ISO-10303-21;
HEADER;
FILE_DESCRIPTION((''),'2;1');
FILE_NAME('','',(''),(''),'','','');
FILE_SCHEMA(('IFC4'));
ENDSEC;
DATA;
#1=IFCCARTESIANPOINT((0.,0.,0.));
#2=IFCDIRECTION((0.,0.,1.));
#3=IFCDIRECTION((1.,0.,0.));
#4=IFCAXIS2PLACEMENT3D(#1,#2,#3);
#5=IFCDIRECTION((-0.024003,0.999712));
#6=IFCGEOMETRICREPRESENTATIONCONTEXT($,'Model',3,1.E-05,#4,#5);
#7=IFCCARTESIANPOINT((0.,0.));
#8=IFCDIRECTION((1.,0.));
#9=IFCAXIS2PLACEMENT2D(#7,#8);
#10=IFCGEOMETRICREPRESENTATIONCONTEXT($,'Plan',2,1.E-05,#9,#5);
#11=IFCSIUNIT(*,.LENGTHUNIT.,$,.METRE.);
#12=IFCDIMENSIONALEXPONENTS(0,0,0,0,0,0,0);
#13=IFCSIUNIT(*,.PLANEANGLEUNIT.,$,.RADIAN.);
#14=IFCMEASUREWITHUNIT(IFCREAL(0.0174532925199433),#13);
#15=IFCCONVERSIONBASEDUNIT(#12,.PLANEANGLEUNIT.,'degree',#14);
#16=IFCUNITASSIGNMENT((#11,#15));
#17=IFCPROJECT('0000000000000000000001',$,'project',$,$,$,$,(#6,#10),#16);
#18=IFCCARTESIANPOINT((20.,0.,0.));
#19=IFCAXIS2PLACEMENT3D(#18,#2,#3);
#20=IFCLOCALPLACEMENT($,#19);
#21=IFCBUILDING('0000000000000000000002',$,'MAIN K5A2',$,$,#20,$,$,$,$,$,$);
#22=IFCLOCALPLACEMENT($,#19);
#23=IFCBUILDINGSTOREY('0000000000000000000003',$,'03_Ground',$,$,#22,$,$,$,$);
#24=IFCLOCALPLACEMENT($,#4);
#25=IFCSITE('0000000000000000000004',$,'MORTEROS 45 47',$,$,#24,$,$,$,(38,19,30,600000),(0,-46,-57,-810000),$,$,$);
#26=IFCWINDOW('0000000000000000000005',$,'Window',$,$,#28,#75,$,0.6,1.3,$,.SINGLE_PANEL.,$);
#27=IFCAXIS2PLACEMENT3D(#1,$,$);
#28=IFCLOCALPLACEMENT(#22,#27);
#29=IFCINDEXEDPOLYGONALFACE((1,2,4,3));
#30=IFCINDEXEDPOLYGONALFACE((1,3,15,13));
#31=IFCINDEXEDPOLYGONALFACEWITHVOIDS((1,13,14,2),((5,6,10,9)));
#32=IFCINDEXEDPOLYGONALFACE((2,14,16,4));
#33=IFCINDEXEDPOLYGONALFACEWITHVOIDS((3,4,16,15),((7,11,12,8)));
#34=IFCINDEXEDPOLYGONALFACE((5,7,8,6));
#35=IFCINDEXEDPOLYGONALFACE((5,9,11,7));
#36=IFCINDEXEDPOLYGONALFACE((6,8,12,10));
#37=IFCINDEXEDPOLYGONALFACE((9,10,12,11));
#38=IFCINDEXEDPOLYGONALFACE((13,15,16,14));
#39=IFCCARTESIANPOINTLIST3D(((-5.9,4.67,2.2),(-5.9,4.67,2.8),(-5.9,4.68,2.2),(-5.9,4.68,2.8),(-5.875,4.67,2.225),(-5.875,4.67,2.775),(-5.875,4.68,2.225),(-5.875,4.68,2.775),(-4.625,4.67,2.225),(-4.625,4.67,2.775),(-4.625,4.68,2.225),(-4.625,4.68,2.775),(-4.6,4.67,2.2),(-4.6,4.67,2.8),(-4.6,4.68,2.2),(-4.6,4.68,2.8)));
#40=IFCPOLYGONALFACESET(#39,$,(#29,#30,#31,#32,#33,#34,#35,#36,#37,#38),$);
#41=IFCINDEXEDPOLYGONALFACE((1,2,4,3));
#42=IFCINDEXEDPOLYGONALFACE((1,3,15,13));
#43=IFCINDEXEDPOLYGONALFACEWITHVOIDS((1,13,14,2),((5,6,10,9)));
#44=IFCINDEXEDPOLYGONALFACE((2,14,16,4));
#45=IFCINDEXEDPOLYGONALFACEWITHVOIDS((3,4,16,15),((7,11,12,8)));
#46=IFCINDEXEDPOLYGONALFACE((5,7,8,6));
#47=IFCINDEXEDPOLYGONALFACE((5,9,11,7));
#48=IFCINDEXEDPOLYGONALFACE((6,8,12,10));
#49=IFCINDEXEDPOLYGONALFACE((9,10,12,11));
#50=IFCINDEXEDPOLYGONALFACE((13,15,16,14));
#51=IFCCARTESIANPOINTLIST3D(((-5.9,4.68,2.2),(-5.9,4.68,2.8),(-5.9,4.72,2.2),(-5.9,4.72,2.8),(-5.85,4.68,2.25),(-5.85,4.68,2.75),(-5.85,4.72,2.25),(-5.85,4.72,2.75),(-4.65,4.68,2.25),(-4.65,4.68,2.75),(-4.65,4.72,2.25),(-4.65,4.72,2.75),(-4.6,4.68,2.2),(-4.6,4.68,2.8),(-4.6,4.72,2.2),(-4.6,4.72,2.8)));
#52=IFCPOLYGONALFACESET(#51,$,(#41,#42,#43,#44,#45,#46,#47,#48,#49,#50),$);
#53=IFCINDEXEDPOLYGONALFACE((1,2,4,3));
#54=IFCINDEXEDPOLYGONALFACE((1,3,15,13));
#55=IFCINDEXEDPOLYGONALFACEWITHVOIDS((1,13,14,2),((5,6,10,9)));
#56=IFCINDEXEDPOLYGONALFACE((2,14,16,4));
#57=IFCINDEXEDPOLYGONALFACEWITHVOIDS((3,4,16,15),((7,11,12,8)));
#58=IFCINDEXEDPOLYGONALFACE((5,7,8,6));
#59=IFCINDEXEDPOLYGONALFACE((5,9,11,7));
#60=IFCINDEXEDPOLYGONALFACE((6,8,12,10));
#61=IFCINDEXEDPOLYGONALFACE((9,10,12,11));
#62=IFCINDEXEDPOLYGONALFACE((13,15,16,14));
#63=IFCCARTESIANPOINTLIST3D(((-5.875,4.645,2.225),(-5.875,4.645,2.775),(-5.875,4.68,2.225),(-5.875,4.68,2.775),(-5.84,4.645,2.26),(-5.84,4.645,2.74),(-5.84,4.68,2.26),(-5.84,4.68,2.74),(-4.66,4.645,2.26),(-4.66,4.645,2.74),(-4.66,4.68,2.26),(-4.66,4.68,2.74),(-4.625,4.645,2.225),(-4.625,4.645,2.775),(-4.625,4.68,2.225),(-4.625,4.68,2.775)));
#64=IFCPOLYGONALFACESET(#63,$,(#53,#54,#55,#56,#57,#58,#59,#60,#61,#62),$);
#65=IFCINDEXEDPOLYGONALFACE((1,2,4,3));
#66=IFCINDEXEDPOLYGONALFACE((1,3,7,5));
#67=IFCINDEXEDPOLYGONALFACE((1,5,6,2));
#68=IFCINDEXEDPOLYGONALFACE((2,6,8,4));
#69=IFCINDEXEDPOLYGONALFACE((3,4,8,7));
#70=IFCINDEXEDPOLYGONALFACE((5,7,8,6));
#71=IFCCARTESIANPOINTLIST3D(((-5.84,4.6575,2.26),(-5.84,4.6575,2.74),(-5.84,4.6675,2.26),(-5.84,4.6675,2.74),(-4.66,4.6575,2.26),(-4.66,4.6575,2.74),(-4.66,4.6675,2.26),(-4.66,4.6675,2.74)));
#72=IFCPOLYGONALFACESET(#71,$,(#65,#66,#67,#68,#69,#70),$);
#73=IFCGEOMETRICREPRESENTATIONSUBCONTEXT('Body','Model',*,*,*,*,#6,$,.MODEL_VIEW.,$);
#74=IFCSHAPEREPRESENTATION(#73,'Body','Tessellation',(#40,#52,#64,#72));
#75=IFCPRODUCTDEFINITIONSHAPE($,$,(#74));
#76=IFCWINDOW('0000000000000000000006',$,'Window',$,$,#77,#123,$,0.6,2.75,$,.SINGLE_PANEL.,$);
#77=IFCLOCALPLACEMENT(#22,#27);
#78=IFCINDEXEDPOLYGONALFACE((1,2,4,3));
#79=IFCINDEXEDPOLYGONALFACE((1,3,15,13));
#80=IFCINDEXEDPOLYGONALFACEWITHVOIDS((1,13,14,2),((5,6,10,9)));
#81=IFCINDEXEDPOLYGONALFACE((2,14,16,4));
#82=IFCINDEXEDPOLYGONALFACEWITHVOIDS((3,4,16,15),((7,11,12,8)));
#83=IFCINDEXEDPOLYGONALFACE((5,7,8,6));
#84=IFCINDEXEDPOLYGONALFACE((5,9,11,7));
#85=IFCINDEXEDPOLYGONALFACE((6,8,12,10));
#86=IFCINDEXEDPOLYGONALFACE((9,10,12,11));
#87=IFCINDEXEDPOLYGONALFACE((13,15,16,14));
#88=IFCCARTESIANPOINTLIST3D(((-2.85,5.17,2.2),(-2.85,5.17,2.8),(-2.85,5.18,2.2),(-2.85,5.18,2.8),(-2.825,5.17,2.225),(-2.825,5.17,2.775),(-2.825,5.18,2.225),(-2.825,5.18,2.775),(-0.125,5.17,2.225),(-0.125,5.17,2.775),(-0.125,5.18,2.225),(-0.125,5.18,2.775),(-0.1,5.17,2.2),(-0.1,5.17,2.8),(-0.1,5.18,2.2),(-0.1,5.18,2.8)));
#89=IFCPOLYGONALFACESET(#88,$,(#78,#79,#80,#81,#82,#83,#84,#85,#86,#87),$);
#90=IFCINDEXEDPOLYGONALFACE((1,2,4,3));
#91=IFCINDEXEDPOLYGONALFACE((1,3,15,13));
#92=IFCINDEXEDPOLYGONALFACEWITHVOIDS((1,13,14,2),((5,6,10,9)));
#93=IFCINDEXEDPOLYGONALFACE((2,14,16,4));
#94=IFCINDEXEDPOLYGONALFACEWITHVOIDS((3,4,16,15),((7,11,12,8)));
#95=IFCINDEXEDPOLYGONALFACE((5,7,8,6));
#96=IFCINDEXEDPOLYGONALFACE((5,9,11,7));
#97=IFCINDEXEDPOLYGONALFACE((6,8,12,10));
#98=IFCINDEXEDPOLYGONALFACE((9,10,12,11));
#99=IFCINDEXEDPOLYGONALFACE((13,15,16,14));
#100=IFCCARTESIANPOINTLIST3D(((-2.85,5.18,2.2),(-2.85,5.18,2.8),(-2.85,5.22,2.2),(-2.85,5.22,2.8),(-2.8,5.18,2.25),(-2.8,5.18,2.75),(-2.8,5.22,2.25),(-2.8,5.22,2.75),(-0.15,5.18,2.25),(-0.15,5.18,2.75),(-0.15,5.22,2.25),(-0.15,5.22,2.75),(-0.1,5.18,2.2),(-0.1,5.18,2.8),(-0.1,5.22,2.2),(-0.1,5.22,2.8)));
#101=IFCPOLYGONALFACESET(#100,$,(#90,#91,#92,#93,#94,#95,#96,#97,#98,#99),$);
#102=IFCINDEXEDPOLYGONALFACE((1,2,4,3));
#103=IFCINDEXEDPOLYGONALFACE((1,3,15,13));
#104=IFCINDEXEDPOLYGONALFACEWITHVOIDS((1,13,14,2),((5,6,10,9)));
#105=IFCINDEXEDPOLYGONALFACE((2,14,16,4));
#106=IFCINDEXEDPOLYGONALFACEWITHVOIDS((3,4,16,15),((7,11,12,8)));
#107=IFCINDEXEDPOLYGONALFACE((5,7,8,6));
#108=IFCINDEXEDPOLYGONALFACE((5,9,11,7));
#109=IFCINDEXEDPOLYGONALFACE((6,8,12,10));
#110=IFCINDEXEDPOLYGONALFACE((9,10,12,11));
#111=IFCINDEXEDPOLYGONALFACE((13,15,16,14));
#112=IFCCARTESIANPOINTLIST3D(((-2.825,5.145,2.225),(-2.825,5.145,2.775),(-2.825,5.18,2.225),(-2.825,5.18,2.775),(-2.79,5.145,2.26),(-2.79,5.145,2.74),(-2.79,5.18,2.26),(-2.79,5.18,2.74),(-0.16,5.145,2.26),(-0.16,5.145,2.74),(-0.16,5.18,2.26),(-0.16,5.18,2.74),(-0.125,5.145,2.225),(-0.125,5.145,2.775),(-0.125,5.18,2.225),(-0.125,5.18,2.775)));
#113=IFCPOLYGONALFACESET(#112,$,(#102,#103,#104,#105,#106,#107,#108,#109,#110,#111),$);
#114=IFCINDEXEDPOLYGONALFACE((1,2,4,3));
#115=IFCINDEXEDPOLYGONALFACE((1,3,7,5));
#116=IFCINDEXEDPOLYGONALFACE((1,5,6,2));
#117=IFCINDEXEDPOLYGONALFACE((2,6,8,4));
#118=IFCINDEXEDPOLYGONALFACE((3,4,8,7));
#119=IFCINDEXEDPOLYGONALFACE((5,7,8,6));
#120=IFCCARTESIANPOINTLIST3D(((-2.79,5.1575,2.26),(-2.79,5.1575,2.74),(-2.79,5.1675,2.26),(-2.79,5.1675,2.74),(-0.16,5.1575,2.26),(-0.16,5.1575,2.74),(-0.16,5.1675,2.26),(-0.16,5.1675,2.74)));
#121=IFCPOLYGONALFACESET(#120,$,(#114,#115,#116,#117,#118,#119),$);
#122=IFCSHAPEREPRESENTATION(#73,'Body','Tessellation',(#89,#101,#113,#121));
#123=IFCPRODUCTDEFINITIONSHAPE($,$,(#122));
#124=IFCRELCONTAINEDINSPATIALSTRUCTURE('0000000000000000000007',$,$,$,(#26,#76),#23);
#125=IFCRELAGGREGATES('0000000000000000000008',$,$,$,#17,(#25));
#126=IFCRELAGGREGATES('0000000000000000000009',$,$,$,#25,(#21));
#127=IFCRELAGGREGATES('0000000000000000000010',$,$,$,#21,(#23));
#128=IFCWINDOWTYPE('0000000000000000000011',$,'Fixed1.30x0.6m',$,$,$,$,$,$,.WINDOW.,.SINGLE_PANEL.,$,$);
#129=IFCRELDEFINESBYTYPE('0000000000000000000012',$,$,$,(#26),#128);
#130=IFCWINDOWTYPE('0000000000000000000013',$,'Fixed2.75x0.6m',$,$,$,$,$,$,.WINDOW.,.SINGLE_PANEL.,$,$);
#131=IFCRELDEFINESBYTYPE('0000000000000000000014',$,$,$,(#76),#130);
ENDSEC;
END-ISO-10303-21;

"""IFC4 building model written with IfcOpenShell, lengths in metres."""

from ifc_helpers import new_model, entity, si_unit, converted_unit, direction, frame, origin_with_axes, origin_2d_with_axis, place, context, subcontext, project, spatial, line, indexed_curve, outline, extrude, shape, source, transform, mapped, type_object, element, save


model = new_model("IFC4")

# Units and contexts
model_context = context("Model", 3, precision=1e-05, world=origin_with_axes(), true_north=direction((-0.024003, 0.999712)))
plan_context = context("Plan", 2, precision=1e-05, world=origin_2d_with_axis(), true_north=direction((-0.024003, 0.999712)))
body_context_1 = subcontext(model_context, "Body", "Model", "MODEL_VIEW")
body_context_2 = subcontext(plan_context, "Body", "Plan", "PLAN_VIEW")
ifc_project = project(units=[si_unit("LENGTHUNIT", "METRE"), converted_unit("PLANEANGLEUNIT", "degree", entity("IfcReal", 0.0174532925199433), si_unit("PLANEANGLEUNIT", "RADIAN"), dimensions=[0, 0, 0, 0, 0, 0, 0])], contexts=[model_context, plan_context])

# Site, building, storey
site_placement = place(None, origin_with_axes())
site = spatial("IfcSite", under=ifc_project, at=site_placement, Name="MORTEROS 45 47", RefLatitude=(38, 19, 30, 600000), RefLongitude=(0, -46, -57, -810000))
building_placement = place(None, frame((20.0, 0.0, 0.0), z_axis=(0.0, 0.0, 1.0), x_axis=(1.0, 0.0, 0.0)))
building = spatial("IfcBuilding", under=site, at=building_placement, Name="MAIN K5A2")
storey_placement = place(None, frame((20.0, 0.0, 0.0), z_axis=(0.0, 0.0, 1.0), x_axis=(1.0, 0.0, 0.0)))
storey = spatial("IfcBuildingStorey", under=building, at=storey_placement, Name="03_Ground")

# Windows
window_type_1 = type_object("IfcWindowType", Name="Fixed1.30x0.6m", PartitioningType="SINGLE_PANEL", PredefinedType="WINDOW")
shared_shape_1 = source(origin_with_axes(), body_context_1, "Body", "SolidModel", [
    extrude(outline(indexed_curve([(0.0, 0.0), (1.3, 0.0), (1.3, 0.6), (0.0, 0.6)], segments=[line(1, 2, 3, 4, 1)]), holes=[indexed_curve([(0.025, 0.025), (1.275, 0.025), (1.275, 0.575), (0.025, 0.575)], segments=[line(1, 2, 3, 4, 1)])]), frame((0.0, 0.09, 0.0), z_axis=(0.0, -1.0, 0.0), x_axis=(1.0, 0.0, 0.0)), (0.0, 0.0, -1.0), 0.01),
    extrude(outline(indexed_curve([(0.0, 0.0), (1.3, 0.0), (1.3, 0.6), (0.0, 0.6)], segments=[line(1, 2, 3, 4, 1)]), holes=[indexed_curve([(0.05, 0.05), (1.25, 0.05), (1.25, 0.55), (0.05, 0.55)], segments=[line(1, 2, 3, 4, 1)])]), frame((0.0, 0.05, 0.0), z_axis=(0.0, -1.0, 0.0), x_axis=(1.0, 0.0, 0.0)), (0.0, 0.0, -1.0), 0.04),
    extrude(outline(indexed_curve([(0.0, 0.0), (1.25, 0.0), (1.25, 0.55), (0.0, 0.55)], segments=[line(1, 2, 3, 4, 1)]), holes=[indexed_curve([(0.035, 0.035), (1.215, 0.035), (1.215, 0.515), (0.035, 0.515)], segments=[line(1, 2, 3, 4, 1)])]), frame((0.025, 0.09, 0.025), z_axis=(0.0, -1.0, 0.0), x_axis=(1.0, 0.0, 0.0)), (0.0, 0.0, -1.0), 0.035),
    extrude(outline(indexed_curve([(0.035, 0.035), (1.215, 0.035), (1.215, 0.515), (0.035, 0.515)], segments=[line(1, 2, 3, 4, 1)])), frame((0.025, 0.1025, 0.025), z_axis=(0.0, -1.0, 0.0), x_axis=(1.0, 0.0, 0.0)), (0.0, 0.0, -1.0), 0.01),
])
shared_shape_2 = source(origin_with_axes(), body_context_2, "Body", "Curve2D", [
    entity("IfcIndexedPolyCurve", entity("IfcCartesianPointList2D", [[0.05, 0.05], [1.25, 0.05]])),
    entity("IfcIndexedPolyCurve", entity("IfcCartesianPointList2D", [[0.0, 0.1], [0.025, 0.1], [0.025, 0.09], [0.05, 0.09], [0.05, 0.05], [0.0, 0.05]]), [entity("IfcLineIndex", [1, 2, 3, 4, 5, 6, 1])]),
    entity("IfcIndexedPolyCurve", entity("IfcCartesianPointList2D", [[1.3, 0.1], [1.275, 0.1], [1.275, 0.09], [1.25, 0.09], [1.25, 0.05], [1.3, 0.05]]), [entity("IfcLineIndex", [1, 2, 3, 4, 5, 6, 1])]),
    entity("IfcIndexedPolyCurve", entity("IfcCartesianPointList2D", [[0.025, 0.09], [0.06, 0.09], [0.06, 0.125], [0.025, 0.125]]), [entity("IfcLineIndex", [1, 2, 3, 4, 1])]),
    entity("IfcIndexedPolyCurve", entity("IfcCartesianPointList2D", [[1.275, 0.09], [1.24, 0.09], [1.24, 0.125], [1.275, 0.125]]), [entity("IfcLineIndex", [1, 2, 3, 4, 1])]),
    entity("IfcIndexedPolyCurve", entity("IfcCartesianPointList2D", [[0.06, 0.09], [1.24, 0.09]])),
    entity("IfcIndexedPolyCurve", entity("IfcCartesianPointList2D", [[0.06, 0.125], [1.24, 0.125]])),
    entity("IfcIndexedPolyCurve", entity("IfcCartesianPointList2D", [[0.06, 0.1075], [1.24, 0.1075]])),
])
window_1_placement = place(None, frame((15.4, 4.77, 2.2), z_axis=(0.0, 0.0, 1.0), x_axis=(-1.0, 0.0, 0.0)))
element("IfcWindow", 1, at=window_1_placement, inside=storey, type_object=window_type_1, Name="Window", OverallHeight=0.6, OverallWidth=1.3, PartitioningType="SINGLE_PANEL", shapes=[
    shape(body_context_1, "Body", "MappedRepresentation", [mapped(shared_shape_1, transform((0.0, 0.0, 0.0), x_axis=(1.0, 0.0, 0.0), y_axis=(0.0, 1.0, 0.0), z_axis=(0.0, 0.0, 1.0), scale=1.0))]),
    shape(body_context_2, "Body", "MappedRepresentation", [mapped(shared_shape_2, transform((0.0, 0.0, 0.0), x_axis=(1.0, 0.0, 0.0), y_axis=(0.0, 1.0, 0.0), z_axis=(0.0, 0.0, 1.0), scale=1.0))]),
])
window_type_2 = type_object("IfcWindowType", Name="Fixed2.75x0.6m", PartitioningType="SINGLE_PANEL", PredefinedType="WINDOW")
shared_shape_3 = source(origin_with_axes(), body_context_1, "Body", "SolidModel", [
    extrude(outline(indexed_curve([(0.0, 0.0), (2.75, 0.0), (2.75, 0.6), (0.0, 0.6)], segments=[line(1, 2, 3, 4, 1)]), holes=[indexed_curve([(0.025, 0.025), (2.725, 0.025), (2.725, 0.575), (0.025, 0.575)], segments=[line(1, 2, 3, 4, 1)])]), frame((0.0, 0.09, 0.0), z_axis=(0.0, -1.0, 0.0), x_axis=(1.0, 0.0, 0.0)), (0.0, 0.0, -1.0), 0.01),
    extrude(outline(indexed_curve([(0.0, 0.0), (2.75, 0.0), (2.75, 0.6), (0.0, 0.6)], segments=[line(1, 2, 3, 4, 1)]), holes=[indexed_curve([(0.05, 0.05), (2.7, 0.05), (2.7, 0.55), (0.05, 0.55)], segments=[line(1, 2, 3, 4, 1)])]), frame((0.0, 0.05, 0.0), z_axis=(0.0, -1.0, 0.0), x_axis=(1.0, 0.0, 0.0)), (0.0, 0.0, -1.0), 0.04),
    extrude(outline(indexed_curve([(0.0, 0.0), (2.7, 0.0), (2.7, 0.55), (0.0, 0.55)], segments=[line(1, 2, 3, 4, 1)]), holes=[indexed_curve([(0.035, 0.035), (2.665, 0.035), (2.665, 0.515), (0.035, 0.515)], segments=[line(1, 2, 3, 4, 1)])]), frame((0.025, 0.09, 0.025), z_axis=(0.0, -1.0, 0.0), x_axis=(1.0, 0.0, 0.0)), (0.0, 0.0, -1.0), 0.035),
    extrude(outline(indexed_curve([(0.035, 0.035), (2.665, 0.035), (2.665, 0.515), (0.035, 0.515)], segments=[line(1, 2, 3, 4, 1)])), frame((0.025, 0.1025, 0.025), z_axis=(0.0, -1.0, 0.0), x_axis=(1.0, 0.0, 0.0)), (0.0, 0.0, -1.0), 0.01),
])
shared_shape_4 = source(origin_with_axes(), body_context_2, "Body", "Curve2D", [
    entity("IfcIndexedPolyCurve", entity("IfcCartesianPointList2D", [[0.05, 0.05], [2.7, 0.05]])),
    entity("IfcIndexedPolyCurve", entity("IfcCartesianPointList2D", [[0.0, 0.1], [0.025, 0.1], [0.025, 0.09], [0.05, 0.09], [0.05, 0.05], [0.0, 0.05]]), [entity("IfcLineIndex", [1, 2, 3, 4, 5, 6, 1])]),
    entity("IfcIndexedPolyCurve", entity("IfcCartesianPointList2D", [[2.75, 0.1], [2.725, 0.1], [2.725, 0.09], [2.7, 0.09], [2.7, 0.05], [2.75, 0.05]]), [entity("IfcLineIndex", [1, 2, 3, 4, 5, 6, 1])]),
    entity("IfcIndexedPolyCurve", entity("IfcCartesianPointList2D", [[0.025, 0.09], [0.06, 0.09], [0.06, 0.125], [0.025, 0.125]]), [entity("IfcLineIndex", [1, 2, 3, 4, 1])]),
    entity("IfcIndexedPolyCurve", entity("IfcCartesianPointList2D", [[2.725, 0.09], [2.69, 0.09], [2.69, 0.125], [2.725, 0.125]]), [entity("IfcLineIndex", [1, 2, 3, 4, 1])]),
    entity("IfcIndexedPolyCurve", entity("IfcCartesianPointList2D", [[0.06, 0.09], [2.69, 0.09]])),
    entity("IfcIndexedPolyCurve", entity("IfcCartesianPointList2D", [[0.06, 0.125], [2.69, 0.125]])),
    entity("IfcIndexedPolyCurve", entity("IfcCartesianPointList2D", [[0.06, 0.1075], [2.69, 0.1075]])),
])
window_2_placement = place(None, frame((19.9, 5.27, 2.2), z_axis=(0.0, 0.0, 1.0), x_axis=(-1.0, 0.0, 0.0)))
element("IfcWindow", 2, at=window_2_placement, inside=storey, type_object=window_type_2, Name="Window", OverallHeight=0.6, OverallWidth=2.75, PartitioningType="SINGLE_PANEL", shapes=[
    shape(body_context_1, "Body", "MappedRepresentation", [mapped(shared_shape_3, transform((0.0, 0.0, 0.0), x_axis=(1.0, 0.0, 0.0), y_axis=(0.0, 1.0, 0.0), z_axis=(0.0, 0.0, 1.0), scale=1.0))]),
    shape(body_context_2, "Body", "MappedRepresentation", [mapped(shared_shape_4, transform((0.0, 0.0, 0.0), x_axis=(1.0, 0.0, 0.0), y_axis=(0.0, 1.0, 0.0), z_axis=(0.0, 0.0, 1.0), scale=1.0))]),
])

save(model, "model.ifc")
